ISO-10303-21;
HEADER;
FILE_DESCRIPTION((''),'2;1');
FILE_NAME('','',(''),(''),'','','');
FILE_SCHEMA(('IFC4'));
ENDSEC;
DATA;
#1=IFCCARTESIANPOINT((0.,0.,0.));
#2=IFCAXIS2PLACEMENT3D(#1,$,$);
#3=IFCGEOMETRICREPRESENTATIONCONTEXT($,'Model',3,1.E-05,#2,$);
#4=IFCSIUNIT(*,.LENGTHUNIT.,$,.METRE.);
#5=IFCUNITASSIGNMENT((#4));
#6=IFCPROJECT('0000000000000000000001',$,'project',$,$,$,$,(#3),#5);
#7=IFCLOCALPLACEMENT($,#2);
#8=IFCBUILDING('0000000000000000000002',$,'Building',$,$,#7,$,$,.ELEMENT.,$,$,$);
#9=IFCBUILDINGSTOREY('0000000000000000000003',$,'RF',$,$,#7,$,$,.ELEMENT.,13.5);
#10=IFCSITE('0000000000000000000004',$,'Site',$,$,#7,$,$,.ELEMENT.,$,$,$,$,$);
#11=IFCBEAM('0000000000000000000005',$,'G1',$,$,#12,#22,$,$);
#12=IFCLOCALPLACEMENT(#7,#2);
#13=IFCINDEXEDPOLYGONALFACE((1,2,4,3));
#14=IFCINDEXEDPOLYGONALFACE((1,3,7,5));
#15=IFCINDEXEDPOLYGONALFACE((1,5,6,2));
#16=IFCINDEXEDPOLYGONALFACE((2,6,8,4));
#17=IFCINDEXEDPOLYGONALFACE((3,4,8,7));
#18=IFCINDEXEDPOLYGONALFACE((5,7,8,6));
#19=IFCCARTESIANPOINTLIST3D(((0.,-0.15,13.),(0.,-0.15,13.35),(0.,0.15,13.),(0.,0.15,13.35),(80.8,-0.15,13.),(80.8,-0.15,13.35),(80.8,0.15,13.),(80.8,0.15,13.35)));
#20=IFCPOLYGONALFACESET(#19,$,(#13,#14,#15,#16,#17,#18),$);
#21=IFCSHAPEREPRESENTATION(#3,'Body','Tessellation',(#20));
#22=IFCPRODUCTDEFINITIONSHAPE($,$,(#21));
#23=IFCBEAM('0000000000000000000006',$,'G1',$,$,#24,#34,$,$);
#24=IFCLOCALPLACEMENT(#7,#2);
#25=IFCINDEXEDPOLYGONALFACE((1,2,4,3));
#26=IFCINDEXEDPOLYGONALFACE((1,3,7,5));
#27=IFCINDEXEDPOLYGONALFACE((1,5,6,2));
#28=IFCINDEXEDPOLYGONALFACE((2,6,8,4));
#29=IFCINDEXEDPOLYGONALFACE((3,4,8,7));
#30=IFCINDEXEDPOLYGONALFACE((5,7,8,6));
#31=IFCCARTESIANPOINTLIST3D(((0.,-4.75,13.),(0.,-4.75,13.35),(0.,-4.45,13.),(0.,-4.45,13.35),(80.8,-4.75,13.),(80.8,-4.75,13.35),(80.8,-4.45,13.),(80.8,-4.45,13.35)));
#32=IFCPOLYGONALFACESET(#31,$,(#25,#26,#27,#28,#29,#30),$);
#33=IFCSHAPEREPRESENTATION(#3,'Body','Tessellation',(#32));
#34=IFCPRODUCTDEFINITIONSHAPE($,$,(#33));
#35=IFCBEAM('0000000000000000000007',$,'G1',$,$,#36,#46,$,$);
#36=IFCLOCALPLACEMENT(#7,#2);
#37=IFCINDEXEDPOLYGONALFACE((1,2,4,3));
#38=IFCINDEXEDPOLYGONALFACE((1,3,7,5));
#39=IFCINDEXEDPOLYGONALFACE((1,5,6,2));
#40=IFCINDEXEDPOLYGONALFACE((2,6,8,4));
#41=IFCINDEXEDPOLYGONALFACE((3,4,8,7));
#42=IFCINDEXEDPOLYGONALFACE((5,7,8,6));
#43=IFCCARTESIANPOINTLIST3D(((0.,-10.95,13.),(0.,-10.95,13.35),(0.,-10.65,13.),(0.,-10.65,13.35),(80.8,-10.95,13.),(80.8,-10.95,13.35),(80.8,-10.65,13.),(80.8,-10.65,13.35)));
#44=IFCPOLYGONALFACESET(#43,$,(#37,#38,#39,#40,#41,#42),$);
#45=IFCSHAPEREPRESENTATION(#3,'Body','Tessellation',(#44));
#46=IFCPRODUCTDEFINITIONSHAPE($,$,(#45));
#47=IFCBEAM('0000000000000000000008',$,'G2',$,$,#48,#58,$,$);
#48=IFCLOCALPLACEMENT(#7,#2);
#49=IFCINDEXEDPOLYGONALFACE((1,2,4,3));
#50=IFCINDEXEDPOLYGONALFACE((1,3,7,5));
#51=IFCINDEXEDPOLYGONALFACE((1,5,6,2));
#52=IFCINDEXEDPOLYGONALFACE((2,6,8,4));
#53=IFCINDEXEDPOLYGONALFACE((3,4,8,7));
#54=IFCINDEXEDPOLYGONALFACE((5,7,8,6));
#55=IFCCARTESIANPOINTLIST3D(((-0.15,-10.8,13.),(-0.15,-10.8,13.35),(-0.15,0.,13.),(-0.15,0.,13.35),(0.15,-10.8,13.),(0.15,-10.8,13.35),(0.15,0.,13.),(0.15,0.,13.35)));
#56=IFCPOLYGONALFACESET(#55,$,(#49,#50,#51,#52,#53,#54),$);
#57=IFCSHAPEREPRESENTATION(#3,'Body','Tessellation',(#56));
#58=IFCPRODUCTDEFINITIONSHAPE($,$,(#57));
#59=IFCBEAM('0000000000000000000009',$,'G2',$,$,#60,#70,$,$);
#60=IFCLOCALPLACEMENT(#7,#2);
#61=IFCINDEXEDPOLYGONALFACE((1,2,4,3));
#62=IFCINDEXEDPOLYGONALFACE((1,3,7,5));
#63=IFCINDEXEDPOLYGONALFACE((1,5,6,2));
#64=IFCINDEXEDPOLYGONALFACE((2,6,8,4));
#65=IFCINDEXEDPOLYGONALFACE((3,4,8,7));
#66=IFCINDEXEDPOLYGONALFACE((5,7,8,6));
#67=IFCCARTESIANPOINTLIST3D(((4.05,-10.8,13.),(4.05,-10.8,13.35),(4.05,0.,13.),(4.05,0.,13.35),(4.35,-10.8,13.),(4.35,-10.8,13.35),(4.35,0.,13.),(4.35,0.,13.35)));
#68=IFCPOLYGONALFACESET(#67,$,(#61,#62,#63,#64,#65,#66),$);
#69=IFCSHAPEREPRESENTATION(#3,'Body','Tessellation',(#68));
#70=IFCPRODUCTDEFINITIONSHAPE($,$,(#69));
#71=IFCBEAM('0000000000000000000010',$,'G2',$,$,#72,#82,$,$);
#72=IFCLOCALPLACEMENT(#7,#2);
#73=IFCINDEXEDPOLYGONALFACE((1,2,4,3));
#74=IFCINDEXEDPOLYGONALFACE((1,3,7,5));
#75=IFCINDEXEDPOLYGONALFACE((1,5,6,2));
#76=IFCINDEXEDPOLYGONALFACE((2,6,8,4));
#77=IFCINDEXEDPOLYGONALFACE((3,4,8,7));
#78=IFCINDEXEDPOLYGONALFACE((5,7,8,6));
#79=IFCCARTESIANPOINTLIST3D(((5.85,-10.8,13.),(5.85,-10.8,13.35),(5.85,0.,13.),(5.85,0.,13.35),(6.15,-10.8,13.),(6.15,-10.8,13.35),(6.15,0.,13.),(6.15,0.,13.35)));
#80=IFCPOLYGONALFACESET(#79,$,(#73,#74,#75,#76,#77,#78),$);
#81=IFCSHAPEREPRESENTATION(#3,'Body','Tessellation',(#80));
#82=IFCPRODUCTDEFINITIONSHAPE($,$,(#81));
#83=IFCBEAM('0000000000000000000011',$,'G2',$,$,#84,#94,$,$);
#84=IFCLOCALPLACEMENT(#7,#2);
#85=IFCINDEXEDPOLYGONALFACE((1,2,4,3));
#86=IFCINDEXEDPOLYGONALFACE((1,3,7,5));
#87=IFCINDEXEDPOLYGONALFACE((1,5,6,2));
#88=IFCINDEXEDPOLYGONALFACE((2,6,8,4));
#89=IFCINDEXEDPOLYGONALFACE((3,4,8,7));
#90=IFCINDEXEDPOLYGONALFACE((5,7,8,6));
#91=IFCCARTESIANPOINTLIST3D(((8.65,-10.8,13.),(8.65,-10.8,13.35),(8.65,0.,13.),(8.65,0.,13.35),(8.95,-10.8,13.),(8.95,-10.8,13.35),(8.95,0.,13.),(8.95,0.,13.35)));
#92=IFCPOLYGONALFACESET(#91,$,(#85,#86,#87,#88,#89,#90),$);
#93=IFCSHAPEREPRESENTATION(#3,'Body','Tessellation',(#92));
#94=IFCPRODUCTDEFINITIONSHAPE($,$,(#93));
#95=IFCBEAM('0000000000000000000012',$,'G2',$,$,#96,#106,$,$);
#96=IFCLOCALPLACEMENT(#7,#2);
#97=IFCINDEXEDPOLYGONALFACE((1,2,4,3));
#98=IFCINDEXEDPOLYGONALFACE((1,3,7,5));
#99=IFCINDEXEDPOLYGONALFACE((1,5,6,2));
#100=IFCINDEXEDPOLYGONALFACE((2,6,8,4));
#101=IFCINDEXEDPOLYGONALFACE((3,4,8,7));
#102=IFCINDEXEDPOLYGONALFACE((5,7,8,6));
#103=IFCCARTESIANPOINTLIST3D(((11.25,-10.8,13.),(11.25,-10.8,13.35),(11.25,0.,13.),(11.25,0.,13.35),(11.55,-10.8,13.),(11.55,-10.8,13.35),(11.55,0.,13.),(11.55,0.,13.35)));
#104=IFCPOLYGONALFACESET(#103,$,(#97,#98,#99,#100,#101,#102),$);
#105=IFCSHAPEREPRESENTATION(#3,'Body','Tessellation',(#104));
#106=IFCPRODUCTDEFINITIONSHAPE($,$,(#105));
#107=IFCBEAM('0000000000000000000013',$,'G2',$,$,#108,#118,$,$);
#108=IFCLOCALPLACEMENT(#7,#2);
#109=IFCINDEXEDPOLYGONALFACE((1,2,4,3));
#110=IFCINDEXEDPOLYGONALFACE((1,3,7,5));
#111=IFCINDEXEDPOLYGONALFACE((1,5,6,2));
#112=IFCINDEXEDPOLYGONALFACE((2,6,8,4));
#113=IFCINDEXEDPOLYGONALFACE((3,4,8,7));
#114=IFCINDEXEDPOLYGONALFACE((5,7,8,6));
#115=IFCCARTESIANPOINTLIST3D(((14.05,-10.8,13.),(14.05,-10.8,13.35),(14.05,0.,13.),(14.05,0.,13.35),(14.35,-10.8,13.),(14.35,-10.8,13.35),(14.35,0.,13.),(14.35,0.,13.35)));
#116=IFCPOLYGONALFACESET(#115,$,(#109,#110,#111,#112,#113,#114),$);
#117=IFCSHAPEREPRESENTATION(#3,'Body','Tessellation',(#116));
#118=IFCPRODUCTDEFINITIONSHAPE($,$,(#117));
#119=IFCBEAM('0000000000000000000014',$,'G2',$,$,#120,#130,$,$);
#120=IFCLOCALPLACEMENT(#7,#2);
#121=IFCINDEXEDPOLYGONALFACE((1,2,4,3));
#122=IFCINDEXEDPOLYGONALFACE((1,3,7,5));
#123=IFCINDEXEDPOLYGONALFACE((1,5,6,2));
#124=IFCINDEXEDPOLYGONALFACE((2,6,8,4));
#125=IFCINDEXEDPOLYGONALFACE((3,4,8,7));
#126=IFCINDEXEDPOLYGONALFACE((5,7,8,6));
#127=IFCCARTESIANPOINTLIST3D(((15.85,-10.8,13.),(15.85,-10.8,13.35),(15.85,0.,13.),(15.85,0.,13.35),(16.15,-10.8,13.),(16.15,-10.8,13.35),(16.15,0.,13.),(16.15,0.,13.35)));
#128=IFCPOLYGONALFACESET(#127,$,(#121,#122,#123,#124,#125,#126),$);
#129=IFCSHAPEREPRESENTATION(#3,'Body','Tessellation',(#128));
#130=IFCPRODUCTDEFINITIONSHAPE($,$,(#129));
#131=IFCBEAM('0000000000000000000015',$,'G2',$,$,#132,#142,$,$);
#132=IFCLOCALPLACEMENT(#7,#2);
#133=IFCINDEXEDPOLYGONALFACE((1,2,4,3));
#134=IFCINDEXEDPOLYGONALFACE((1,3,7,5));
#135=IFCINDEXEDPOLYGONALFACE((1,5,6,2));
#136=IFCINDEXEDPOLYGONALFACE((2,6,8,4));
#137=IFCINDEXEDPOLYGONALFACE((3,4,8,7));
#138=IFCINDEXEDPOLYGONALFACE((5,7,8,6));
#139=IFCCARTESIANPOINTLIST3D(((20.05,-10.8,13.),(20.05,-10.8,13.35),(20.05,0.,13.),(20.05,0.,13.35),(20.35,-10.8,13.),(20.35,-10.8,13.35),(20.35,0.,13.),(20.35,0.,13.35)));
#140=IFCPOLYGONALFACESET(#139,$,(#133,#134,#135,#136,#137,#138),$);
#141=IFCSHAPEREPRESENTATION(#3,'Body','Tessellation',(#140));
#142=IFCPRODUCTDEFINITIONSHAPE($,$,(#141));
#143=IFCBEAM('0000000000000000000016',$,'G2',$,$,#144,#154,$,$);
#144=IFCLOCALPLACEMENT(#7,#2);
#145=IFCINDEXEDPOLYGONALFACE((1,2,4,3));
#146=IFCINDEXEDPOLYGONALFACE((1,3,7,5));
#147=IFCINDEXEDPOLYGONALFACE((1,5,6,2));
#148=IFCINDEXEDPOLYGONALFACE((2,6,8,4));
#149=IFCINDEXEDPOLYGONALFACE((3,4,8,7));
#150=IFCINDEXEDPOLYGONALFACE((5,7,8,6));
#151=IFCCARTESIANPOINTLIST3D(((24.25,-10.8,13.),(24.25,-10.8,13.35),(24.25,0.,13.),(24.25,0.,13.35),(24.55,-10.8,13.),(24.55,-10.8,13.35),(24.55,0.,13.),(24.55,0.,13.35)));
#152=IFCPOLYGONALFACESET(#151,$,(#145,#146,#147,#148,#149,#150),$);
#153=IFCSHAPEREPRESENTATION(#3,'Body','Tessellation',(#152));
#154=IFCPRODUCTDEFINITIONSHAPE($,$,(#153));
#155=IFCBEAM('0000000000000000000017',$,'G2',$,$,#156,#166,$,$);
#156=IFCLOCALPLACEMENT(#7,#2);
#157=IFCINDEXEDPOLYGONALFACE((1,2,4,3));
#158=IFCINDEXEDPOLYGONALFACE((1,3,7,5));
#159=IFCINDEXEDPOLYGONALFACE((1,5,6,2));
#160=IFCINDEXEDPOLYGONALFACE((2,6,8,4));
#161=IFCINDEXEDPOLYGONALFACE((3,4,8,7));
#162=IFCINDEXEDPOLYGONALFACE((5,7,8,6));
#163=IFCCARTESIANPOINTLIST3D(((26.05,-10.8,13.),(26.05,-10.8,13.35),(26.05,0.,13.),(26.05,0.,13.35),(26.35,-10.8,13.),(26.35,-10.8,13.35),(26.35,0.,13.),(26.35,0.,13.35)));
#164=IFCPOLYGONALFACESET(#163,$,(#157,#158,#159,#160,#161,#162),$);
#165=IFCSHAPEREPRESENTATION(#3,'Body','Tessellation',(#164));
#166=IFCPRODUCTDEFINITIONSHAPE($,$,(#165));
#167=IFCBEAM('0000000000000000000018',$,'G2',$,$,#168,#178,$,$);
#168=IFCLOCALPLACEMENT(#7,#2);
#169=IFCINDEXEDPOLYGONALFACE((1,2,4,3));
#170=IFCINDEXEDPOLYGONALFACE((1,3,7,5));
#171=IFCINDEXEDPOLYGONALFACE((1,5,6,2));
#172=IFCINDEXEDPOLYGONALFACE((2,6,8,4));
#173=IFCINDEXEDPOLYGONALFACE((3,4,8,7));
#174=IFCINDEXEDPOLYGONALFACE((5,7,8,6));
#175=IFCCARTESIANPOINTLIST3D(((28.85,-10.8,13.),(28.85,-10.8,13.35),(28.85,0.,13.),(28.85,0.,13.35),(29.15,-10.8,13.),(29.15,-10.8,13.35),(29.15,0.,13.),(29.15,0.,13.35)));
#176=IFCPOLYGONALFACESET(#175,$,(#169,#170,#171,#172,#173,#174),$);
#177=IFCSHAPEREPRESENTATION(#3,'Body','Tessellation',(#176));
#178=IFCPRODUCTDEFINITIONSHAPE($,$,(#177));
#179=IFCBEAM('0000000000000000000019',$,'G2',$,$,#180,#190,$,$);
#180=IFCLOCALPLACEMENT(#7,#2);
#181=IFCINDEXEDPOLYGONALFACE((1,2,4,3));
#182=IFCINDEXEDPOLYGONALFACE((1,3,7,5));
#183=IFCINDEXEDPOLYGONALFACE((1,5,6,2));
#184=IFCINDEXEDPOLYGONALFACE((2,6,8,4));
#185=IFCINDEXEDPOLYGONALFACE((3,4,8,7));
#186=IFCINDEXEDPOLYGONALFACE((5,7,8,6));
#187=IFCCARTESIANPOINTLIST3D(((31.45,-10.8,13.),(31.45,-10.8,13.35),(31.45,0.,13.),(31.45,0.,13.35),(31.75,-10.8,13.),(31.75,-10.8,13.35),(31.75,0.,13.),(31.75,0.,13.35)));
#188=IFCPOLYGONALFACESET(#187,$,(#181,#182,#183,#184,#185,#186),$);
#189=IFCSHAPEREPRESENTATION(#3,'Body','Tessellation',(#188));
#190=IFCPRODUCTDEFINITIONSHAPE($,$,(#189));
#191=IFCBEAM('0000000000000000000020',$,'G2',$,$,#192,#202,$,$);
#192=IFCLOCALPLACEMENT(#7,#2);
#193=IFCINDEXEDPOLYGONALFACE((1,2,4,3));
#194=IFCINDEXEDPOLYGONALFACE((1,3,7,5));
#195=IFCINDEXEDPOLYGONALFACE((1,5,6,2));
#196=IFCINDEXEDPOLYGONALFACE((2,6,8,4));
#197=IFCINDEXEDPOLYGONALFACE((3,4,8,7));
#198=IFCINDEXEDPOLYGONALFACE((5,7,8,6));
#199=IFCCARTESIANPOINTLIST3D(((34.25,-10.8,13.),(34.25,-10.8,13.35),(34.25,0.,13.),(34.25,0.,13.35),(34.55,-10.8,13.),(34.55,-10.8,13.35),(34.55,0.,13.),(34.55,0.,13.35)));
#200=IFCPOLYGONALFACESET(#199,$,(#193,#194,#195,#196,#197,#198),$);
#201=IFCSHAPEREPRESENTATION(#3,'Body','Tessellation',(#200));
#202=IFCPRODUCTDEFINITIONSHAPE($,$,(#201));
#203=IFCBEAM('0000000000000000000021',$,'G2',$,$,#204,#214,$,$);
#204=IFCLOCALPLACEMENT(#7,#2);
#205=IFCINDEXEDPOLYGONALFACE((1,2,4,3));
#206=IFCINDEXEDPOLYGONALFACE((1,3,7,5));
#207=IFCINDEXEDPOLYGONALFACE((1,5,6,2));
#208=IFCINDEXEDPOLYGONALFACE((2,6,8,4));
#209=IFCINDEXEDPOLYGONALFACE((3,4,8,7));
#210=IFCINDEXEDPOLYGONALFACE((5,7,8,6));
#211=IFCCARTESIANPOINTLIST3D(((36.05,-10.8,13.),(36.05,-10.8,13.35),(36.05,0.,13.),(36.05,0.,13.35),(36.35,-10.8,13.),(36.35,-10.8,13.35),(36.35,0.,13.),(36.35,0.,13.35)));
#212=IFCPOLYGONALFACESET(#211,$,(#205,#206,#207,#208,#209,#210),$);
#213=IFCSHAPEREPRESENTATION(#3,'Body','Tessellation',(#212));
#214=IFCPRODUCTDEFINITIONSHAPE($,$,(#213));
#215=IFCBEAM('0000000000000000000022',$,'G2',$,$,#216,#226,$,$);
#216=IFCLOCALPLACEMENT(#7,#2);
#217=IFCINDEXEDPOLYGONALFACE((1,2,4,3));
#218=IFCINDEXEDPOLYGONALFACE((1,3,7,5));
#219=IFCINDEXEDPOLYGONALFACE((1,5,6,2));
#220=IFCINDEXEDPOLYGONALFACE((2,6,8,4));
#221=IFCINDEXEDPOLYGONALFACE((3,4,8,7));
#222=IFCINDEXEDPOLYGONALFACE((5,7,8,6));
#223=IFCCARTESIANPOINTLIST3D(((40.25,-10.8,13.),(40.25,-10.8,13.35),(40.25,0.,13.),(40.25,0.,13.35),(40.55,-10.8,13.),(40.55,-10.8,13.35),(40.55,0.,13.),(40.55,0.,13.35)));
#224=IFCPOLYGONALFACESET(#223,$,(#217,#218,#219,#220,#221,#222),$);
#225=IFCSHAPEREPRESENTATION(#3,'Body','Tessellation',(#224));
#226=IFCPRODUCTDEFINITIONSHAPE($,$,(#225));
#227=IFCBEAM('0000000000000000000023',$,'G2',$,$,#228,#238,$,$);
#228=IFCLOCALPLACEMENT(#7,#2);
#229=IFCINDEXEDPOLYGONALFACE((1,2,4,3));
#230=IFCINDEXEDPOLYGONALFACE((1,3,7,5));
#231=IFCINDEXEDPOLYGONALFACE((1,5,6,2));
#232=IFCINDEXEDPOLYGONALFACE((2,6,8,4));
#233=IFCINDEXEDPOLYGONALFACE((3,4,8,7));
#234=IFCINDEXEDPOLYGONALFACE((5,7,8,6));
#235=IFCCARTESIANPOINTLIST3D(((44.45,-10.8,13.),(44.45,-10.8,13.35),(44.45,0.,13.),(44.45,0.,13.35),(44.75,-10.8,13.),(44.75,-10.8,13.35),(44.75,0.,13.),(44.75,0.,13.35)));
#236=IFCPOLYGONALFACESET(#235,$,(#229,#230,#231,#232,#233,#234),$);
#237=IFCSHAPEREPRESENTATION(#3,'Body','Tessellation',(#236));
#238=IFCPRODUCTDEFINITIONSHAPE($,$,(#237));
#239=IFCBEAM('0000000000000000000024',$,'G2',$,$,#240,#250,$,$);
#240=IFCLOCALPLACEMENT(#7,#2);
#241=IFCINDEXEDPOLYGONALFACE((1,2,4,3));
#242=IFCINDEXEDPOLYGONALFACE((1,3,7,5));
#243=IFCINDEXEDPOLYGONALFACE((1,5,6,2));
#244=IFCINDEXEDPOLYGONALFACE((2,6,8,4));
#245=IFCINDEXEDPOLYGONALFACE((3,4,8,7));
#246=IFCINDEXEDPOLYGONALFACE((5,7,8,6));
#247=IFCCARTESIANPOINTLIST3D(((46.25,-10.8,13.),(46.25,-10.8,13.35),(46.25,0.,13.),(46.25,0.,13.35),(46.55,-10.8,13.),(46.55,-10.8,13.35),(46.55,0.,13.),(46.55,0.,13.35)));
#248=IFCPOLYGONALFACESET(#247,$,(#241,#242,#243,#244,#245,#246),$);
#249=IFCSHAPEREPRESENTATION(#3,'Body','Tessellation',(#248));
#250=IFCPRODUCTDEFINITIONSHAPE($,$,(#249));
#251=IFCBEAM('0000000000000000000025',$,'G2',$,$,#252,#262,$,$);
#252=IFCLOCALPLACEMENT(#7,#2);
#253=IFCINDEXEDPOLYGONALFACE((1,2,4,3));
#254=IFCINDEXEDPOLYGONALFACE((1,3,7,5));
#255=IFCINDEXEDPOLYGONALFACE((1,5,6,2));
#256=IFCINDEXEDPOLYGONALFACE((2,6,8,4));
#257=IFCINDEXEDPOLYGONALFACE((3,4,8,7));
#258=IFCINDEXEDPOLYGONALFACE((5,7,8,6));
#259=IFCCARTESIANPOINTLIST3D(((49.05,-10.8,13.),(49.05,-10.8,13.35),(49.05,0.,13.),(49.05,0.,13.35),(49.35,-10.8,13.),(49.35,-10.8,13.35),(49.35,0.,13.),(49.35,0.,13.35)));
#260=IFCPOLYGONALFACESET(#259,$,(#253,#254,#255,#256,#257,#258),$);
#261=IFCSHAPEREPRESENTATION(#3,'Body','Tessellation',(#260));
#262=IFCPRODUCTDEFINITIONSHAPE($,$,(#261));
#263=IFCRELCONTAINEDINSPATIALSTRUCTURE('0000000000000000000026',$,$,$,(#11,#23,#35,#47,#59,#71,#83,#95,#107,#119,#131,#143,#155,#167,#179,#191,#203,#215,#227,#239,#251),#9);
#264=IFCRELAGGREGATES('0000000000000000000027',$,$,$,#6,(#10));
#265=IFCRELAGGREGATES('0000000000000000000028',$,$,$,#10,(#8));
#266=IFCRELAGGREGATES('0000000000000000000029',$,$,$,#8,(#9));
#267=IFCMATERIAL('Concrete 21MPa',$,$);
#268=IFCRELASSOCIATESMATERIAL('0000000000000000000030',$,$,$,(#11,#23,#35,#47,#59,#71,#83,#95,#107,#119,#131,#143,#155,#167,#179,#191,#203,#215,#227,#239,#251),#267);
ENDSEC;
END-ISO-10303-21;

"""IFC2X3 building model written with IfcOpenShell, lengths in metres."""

from ifc_helpers import new_model, si_unit, frame, origin, origin_2d, place, context, project, spatial, rectangle, extrude, material, element, save


model = new_model("IFC2X3")

# Units and contexts
model_context = context("Model", 3, precision=1e-05, world=origin())
ifc_project = project(units=[si_unit("LENGTHUNIT", "METRE")], contexts=[model_context])

# Site, building, storey
placement = place(None, origin())
site = spatial("IfcSite", under=ifc_project, at=placement, Name="Site", CompositionType="ELEMENT")
building = spatial("IfcBuilding", under=site, at=placement, Name="Building", CompositionType="ELEMENT")
storey = spatial("IfcBuildingStorey", under=building, at=placement, Name="RF", CompositionType="ELEMENT", Elevation=13.5)

# Beams
ifc_material = material(Name="Concrete 21MPa")
for number, where, name in (
    (1, (40.4, 0.0, 13.0), "G1"),
    (2, (40.4, -4.6, 13.0), "G1"),
    (3, (40.4, -10.8, 13.0), "G1"),
):
    element("IfcBeam", number, at=place(None, frame(where)), inside=storey, material=ifc_material, Name=name, context=model_context, shape_type="SweptSolid", body=[
        extrude(rectangle(XDim=80.8, YDim=0.3, at=origin_2d()), origin(), (0.0, 0.0, 1.0), 0.35),
    ])
for number, where, name in (
    (4, (0.0, -5.4, 13.0), "G2"),
    (5, (4.2, -5.4, 13.0), "G2"),
    (6, (6.0, -5.4, 13.0), "G2"),
    (7, (8.8, -5.4, 13.0), "G2"),
    (8, (11.4, -5.4, 13.0), "G2"),
    (9, (14.2, -5.4, 13.0), "G2"),
    (10, (16.0, -5.4, 13.0), "G2"),
    (11, (20.2, -5.4, 13.0), "G2"),
    (12, (24.4, -5.4, 13.0), "G2"),
    (13, (26.2, -5.4, 13.0), "G2"),
    (14, (29.0, -5.4, 13.0), "G2"),
    (15, (31.6, -5.4, 13.0), "G2"),
    (16, (34.4, -5.4, 13.0), "G2"),
    (17, (36.2, -5.4, 13.0), "G2"),
    (18, (40.4, -5.4, 13.0), "G2"),
    (19, (44.6, -5.4, 13.0), "G2"),
    (20, (46.4, -5.4, 13.0), "G2"),
    (21, (49.2, -5.4, 13.0), "G2"),
):
    element("IfcBeam", number, at=place(None, frame(where)), inside=storey, material=ifc_material, Name=name, context=model_context, shape_type="SweptSolid", body=[
        extrude(rectangle(XDim=0.3, YDim=10.8, at=origin_2d()), origin(), (0.0, 0.0, 1.0), 0.35),
    ])

save(model, "model.ifc")
